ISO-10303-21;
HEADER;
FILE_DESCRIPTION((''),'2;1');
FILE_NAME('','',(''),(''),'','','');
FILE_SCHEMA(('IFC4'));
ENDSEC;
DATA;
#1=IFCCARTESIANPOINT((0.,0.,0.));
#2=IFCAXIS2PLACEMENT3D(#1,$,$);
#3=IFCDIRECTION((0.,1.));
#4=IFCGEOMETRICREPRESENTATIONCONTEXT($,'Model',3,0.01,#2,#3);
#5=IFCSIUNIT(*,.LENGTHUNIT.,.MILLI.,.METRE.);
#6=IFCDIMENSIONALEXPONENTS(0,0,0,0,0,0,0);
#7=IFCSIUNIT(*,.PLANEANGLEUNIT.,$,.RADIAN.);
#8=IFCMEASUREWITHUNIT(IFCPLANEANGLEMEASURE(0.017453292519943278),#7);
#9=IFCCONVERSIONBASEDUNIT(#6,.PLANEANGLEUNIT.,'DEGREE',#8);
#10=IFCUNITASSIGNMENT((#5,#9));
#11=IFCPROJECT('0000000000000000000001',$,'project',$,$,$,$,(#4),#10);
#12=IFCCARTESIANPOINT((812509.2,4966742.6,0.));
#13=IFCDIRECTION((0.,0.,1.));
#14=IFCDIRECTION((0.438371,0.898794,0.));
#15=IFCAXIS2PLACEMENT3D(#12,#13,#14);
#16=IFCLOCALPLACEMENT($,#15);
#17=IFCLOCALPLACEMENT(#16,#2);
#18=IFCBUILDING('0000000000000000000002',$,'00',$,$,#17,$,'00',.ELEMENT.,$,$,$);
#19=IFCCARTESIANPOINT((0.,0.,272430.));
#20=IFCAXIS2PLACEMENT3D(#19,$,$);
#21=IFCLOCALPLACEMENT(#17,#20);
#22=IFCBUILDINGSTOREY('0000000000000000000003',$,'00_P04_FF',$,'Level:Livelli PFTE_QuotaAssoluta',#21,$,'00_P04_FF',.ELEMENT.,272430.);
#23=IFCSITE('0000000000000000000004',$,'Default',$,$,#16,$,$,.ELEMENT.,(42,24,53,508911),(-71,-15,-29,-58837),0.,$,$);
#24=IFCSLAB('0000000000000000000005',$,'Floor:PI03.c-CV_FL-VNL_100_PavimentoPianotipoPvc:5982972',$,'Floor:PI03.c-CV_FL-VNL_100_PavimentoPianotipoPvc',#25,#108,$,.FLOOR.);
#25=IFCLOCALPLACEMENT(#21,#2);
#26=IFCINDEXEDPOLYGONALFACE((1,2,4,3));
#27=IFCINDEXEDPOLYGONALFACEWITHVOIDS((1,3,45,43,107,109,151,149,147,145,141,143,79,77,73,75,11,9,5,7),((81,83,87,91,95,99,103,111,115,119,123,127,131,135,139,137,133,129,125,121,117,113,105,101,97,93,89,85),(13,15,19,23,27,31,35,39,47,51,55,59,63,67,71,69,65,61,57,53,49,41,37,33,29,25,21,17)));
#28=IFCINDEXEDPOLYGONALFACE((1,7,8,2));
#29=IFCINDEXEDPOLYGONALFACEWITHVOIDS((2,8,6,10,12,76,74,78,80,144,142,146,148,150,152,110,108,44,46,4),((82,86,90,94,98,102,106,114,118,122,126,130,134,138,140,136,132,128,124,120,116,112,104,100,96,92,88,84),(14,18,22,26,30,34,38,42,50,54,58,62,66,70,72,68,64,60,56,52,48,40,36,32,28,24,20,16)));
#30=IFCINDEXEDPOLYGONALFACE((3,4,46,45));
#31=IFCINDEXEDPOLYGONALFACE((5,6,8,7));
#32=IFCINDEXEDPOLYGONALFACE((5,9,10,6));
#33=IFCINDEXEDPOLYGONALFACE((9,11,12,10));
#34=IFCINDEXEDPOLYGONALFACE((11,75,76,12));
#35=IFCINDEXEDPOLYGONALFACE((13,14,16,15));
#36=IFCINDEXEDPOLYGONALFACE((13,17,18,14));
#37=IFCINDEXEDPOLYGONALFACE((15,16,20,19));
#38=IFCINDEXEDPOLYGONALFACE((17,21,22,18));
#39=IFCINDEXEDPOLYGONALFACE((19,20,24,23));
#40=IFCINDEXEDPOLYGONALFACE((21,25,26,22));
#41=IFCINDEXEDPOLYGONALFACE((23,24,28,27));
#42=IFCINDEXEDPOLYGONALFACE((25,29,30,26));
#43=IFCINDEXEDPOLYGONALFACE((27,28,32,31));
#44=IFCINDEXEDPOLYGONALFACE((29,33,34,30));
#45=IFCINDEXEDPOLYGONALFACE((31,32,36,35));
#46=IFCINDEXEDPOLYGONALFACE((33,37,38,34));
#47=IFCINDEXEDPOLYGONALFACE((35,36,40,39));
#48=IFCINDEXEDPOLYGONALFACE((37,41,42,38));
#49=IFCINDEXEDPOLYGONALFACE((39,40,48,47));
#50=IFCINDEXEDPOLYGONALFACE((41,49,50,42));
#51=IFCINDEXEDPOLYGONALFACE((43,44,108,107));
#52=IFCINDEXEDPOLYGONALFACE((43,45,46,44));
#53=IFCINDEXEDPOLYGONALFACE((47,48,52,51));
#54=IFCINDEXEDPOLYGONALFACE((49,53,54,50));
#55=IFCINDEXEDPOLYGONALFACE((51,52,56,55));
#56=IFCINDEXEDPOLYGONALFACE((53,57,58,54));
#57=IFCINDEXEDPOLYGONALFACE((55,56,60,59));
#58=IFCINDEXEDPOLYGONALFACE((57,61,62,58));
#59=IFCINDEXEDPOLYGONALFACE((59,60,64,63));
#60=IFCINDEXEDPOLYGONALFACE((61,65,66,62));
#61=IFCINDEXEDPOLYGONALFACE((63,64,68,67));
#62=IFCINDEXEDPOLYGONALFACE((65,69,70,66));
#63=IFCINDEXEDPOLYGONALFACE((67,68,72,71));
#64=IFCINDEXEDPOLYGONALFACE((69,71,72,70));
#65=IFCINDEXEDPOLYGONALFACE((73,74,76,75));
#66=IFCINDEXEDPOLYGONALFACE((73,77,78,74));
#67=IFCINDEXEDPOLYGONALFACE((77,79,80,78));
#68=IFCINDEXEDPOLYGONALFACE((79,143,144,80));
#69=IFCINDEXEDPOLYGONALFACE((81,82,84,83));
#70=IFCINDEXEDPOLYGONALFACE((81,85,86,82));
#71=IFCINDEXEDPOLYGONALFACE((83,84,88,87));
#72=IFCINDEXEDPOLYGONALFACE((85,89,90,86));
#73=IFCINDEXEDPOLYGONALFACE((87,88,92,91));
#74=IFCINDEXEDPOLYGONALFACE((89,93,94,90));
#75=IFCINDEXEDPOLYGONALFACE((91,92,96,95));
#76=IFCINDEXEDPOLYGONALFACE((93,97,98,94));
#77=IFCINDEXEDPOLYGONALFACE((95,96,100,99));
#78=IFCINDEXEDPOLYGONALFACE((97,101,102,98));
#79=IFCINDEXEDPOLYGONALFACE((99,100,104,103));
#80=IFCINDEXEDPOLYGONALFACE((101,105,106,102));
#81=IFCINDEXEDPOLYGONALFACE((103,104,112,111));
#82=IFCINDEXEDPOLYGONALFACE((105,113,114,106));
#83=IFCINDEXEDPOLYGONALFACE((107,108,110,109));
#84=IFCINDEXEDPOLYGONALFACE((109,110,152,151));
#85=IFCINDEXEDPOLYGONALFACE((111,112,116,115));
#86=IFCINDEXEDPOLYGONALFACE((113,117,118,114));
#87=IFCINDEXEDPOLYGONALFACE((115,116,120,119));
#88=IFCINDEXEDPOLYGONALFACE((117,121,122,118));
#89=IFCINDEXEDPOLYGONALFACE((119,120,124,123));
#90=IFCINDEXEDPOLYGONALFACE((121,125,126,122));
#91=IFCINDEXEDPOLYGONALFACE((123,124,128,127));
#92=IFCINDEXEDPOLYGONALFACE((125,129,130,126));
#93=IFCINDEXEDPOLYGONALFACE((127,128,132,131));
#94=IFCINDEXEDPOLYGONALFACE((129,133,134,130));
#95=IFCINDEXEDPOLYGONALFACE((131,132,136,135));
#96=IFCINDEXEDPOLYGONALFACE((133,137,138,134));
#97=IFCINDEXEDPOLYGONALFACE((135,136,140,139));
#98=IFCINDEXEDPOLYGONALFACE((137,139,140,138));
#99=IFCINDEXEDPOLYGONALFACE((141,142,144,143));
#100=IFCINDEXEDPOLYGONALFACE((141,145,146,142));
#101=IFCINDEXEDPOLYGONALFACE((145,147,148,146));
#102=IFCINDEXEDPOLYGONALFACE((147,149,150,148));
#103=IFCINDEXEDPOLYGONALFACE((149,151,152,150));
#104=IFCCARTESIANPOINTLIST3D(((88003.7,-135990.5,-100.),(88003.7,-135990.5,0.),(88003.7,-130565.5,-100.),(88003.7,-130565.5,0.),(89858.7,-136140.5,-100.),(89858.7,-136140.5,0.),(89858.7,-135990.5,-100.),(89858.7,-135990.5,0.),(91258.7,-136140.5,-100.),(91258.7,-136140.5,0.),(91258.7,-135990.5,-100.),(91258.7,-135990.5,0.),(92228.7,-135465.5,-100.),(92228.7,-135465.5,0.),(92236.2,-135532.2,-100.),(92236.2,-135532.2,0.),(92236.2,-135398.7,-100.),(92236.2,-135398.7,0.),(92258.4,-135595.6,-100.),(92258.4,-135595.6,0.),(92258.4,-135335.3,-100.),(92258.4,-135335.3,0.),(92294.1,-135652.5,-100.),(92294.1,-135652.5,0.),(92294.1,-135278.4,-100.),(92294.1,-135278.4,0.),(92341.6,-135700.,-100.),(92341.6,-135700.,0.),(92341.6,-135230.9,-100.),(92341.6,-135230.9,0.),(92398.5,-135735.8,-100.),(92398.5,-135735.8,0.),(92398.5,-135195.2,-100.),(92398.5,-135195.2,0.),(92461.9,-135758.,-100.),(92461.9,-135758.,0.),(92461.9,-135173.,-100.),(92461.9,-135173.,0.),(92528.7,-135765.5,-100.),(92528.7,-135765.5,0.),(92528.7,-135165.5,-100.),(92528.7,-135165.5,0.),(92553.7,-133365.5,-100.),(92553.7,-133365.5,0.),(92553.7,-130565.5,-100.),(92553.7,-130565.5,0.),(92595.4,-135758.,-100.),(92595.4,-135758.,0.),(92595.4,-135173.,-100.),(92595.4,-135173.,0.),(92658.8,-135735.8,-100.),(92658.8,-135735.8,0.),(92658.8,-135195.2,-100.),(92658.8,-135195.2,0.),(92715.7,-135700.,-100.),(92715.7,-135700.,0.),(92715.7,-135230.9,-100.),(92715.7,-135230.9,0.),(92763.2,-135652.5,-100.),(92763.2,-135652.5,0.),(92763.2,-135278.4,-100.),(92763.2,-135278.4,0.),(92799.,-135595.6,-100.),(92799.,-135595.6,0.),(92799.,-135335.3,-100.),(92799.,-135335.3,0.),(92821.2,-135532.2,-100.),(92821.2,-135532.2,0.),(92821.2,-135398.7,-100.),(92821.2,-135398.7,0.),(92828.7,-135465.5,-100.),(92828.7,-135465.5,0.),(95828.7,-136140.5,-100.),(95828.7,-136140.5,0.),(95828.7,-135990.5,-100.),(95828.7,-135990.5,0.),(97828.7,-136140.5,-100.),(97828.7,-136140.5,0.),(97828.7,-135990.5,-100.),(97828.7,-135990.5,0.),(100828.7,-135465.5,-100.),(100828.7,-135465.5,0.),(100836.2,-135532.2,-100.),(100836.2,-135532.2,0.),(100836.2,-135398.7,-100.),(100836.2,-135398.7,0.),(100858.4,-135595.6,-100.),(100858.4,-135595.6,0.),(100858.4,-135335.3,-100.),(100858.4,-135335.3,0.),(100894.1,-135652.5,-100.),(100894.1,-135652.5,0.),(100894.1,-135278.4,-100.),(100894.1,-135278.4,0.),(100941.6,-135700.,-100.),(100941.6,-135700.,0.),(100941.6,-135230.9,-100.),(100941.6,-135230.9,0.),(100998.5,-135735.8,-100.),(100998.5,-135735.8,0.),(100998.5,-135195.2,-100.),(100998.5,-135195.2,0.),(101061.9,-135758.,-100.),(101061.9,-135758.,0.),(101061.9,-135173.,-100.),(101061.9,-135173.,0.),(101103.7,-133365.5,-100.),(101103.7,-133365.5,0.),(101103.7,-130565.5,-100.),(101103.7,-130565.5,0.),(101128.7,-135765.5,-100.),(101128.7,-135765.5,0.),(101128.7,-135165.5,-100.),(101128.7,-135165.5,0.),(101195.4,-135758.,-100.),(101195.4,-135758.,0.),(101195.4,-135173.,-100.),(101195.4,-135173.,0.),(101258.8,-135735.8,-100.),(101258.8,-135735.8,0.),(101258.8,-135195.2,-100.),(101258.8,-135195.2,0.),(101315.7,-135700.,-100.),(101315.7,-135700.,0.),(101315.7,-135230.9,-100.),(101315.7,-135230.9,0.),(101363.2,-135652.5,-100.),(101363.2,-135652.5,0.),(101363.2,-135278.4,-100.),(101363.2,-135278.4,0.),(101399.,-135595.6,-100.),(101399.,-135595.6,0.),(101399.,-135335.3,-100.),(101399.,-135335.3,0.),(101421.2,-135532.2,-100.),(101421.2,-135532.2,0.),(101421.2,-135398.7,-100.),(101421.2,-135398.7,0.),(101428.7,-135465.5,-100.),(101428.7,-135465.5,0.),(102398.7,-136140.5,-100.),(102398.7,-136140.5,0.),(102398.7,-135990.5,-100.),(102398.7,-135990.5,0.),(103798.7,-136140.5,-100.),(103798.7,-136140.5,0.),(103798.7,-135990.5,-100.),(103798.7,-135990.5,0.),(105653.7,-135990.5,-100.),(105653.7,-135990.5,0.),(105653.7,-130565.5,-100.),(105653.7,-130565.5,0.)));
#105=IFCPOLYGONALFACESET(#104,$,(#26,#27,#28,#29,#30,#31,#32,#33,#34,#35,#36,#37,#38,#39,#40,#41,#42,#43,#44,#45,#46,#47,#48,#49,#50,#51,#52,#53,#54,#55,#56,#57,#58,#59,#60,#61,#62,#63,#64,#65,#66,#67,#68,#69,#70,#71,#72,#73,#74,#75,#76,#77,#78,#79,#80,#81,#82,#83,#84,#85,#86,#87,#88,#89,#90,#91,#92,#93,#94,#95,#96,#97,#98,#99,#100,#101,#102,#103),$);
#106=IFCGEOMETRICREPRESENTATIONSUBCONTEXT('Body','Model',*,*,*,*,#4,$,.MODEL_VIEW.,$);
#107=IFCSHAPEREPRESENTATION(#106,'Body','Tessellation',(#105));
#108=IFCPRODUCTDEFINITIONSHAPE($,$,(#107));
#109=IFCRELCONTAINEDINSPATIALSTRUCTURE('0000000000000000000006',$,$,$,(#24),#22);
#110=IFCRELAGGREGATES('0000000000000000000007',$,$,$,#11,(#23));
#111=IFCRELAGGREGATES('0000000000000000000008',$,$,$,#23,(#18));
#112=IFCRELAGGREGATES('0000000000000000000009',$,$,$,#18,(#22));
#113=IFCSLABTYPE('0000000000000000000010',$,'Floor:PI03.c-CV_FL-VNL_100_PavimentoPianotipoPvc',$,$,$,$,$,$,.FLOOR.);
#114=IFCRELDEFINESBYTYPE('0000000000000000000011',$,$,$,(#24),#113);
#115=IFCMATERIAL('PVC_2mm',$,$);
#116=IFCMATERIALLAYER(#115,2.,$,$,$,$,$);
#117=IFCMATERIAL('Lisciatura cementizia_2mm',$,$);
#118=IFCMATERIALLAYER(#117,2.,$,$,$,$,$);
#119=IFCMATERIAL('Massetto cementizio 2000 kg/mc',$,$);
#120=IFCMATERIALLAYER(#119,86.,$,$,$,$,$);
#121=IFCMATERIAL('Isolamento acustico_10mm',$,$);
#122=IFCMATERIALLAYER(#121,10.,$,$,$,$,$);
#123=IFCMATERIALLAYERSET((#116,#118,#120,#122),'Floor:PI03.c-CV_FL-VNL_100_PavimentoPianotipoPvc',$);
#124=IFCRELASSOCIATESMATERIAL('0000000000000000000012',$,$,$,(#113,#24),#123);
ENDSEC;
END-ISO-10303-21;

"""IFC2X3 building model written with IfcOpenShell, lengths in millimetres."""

from ifc_helpers import new_model, entity, si_unit, converted_unit, direction, frame, frame_2d, origin, place, context, subcontext, project, spatial, polyline, circle, outline, extrude, material, layer, layer_set, layer_usage, type_object, element, save


model = new_model("IFC2X3")

# Units and contexts
model_context = context("Model", 3, precision=0.01, world=origin(), true_north=direction((0.0, 1.0)))
body_context = subcontext(model_context, "Body", "Model", "MODEL_VIEW")
ifc_project = project(units=[si_unit("LENGTHUNIT", "METRE", prefix="MILLI"), converted_unit("PLANEANGLEUNIT", "DEGREE", entity("IfcPlaneAngleMeasure", 0.017453292519943278), si_unit("PLANEANGLEUNIT", "RADIAN"), dimensions=[0, 0, 0, 0, 0, 0, 0])], contexts=[model_context])

# Site, building, storey
site_placement = place(None, frame((812509.2, 4966742.6, 0.0), z_axis=(0.0, 0.0, 1.0), x_axis=(0.438371, 0.898794, 0.0)))
site = spatial("IfcSite", under=ifc_project, at=site_placement, Name="Default", CompositionType="ELEMENT", RefLatitude=(42, 24, 53, 508911), RefLongitude=(-71, -15, -29, -58837), RefElevation=0.0)
building_placement = place(site_placement, origin())
building = spatial("IfcBuilding", under=site, at=building_placement, Name="00", LongName="00", CompositionType="ELEMENT")
storey_placement = place(building_placement, frame((0.0, 0.0, 272430.0)))
storey = spatial("IfcBuildingStorey", under=building, at=storey_placement, Name="00_P04_FF", ObjectType="Level:Livelli PFTE_QuotaAssoluta", LongName="00_P04_FF", CompositionType="ELEMENT", Elevation=272430.0)

# Slab, openings
ifc_material_1 = material(Name="Massetto cementizio 2000 kg/mc")
ifc_material_2 = material(Name="Isolamento acustico_10mm")
ifc_material_3 = material(Name="PVC_2mm")
ifc_layer_1 = layer(ifc_material_3, 2.0)
ifc_material_4 = material(Name="Lisciatura cementizia_2mm")
ifc_layer_2 = layer(ifc_material_4, 2.0)
ifc_layer_3 = layer(ifc_material_1, 86.0)
ifc_layer_4 = layer(ifc_material_2, 10.0)
ifc_layer_set_1 = layer_set([ifc_layer_1, ifc_layer_2, ifc_layer_3, ifc_layer_4], Name="Floor:PI03.c-CV_FL-VNL_100_PavimentoPianotipoPvc")
ifc_layer_usage_1 = layer_usage(ifc_layer_set_1, "AXIS3", "POSITIVE", 0.0)
slab_type_1 = type_object("IfcSlabType", Name="Floor:PI03.c-CV_FL-VNL_100_PavimentoPianotipoPvc", PredefinedType="FLOOR", material=ifc_layer_set_1)
slab_1_placement = place(storey_placement, frame((88003.7, -136140.5, -100.0)))
slab_1 = element("IfcSlab", 1, at=slab_1_placement, inside=storey, type_object=slab_type_1, material=ifc_layer_usage_1, Name="Floor:PI03.c-CV_FL-VNL_100_PavimentoPianotipoPvc:5982972", ObjectType="Floor:PI03.c-CV_FL-VNL_100_PavimentoPianotipoPvc", PredefinedType="FLOOR", context=body_context, shape_type="SweptSolid", body=[
    extrude(outline(polyline([(-6970.0, -2637.5), (-6970.0, -2787.5), (-5570.0, -2787.5), (-5570.0, -2637.5), (-1000.0, -2637.5), (-1000.0, -2787.5), (1000.0, -2787.5), (1000.0, -2637.5), (5570.0, -2637.5), (5570.0, -2787.5), (6970.0, -2787.5), (6970.0, -2637.5), (8825.0, -2637.5), (8825.0, 2787.5), (4275.0, 2787.5), (4275.0, -12.5), (-4275.0, -12.5), (-4275.0, 2787.5), (-8825.0, 2787.5), (-8825.0, -2637.5), (-6970.0, -2637.5)])), frame((8825.0, 2787.5, 100.0), z_axis=(0.0, 0.0, -1.0), x_axis=(-1.0, 0.0, 0.0)), (0.0, 0.0, 1.0), 100.0),
])
opening_1_placement = place(slab_1_placement, origin())
element("IfcOpeningElement", 2, at=opening_1_placement, cuts=slab_1, ObjectType="Opening", context=body_context, shape_type="SweptSolid", body=[
    extrude(circle(Radius=300.0, at=frame_2d((0.0, 0.0), x_axis=(1.0, 0.0))), frame((13125.0, 675.0, 100.0), z_axis=(0.0, 0.0, -1.0), x_axis=(1.0, 0.0, 0.0)), (0.0, 0.0, 1.0), 100.0),
])
opening_2_placement = place(slab_1_placement, origin())
element("IfcOpeningElement", 3, at=opening_2_placement, cuts=slab_1, ObjectType="Opening", context=body_context, shape_type="SweptSolid", body=[
    extrude(circle(Radius=300.0, at=frame_2d((0.0, 0.0), x_axis=(1.0, 0.0))), frame((4525.0, 675.0, 100.0), z_axis=(0.0, 0.0, -1.0), x_axis=(1.0, 0.0, 0.0)), (0.0, 0.0, 1.0), 100.0),
])

save(model, "model.ifc")
